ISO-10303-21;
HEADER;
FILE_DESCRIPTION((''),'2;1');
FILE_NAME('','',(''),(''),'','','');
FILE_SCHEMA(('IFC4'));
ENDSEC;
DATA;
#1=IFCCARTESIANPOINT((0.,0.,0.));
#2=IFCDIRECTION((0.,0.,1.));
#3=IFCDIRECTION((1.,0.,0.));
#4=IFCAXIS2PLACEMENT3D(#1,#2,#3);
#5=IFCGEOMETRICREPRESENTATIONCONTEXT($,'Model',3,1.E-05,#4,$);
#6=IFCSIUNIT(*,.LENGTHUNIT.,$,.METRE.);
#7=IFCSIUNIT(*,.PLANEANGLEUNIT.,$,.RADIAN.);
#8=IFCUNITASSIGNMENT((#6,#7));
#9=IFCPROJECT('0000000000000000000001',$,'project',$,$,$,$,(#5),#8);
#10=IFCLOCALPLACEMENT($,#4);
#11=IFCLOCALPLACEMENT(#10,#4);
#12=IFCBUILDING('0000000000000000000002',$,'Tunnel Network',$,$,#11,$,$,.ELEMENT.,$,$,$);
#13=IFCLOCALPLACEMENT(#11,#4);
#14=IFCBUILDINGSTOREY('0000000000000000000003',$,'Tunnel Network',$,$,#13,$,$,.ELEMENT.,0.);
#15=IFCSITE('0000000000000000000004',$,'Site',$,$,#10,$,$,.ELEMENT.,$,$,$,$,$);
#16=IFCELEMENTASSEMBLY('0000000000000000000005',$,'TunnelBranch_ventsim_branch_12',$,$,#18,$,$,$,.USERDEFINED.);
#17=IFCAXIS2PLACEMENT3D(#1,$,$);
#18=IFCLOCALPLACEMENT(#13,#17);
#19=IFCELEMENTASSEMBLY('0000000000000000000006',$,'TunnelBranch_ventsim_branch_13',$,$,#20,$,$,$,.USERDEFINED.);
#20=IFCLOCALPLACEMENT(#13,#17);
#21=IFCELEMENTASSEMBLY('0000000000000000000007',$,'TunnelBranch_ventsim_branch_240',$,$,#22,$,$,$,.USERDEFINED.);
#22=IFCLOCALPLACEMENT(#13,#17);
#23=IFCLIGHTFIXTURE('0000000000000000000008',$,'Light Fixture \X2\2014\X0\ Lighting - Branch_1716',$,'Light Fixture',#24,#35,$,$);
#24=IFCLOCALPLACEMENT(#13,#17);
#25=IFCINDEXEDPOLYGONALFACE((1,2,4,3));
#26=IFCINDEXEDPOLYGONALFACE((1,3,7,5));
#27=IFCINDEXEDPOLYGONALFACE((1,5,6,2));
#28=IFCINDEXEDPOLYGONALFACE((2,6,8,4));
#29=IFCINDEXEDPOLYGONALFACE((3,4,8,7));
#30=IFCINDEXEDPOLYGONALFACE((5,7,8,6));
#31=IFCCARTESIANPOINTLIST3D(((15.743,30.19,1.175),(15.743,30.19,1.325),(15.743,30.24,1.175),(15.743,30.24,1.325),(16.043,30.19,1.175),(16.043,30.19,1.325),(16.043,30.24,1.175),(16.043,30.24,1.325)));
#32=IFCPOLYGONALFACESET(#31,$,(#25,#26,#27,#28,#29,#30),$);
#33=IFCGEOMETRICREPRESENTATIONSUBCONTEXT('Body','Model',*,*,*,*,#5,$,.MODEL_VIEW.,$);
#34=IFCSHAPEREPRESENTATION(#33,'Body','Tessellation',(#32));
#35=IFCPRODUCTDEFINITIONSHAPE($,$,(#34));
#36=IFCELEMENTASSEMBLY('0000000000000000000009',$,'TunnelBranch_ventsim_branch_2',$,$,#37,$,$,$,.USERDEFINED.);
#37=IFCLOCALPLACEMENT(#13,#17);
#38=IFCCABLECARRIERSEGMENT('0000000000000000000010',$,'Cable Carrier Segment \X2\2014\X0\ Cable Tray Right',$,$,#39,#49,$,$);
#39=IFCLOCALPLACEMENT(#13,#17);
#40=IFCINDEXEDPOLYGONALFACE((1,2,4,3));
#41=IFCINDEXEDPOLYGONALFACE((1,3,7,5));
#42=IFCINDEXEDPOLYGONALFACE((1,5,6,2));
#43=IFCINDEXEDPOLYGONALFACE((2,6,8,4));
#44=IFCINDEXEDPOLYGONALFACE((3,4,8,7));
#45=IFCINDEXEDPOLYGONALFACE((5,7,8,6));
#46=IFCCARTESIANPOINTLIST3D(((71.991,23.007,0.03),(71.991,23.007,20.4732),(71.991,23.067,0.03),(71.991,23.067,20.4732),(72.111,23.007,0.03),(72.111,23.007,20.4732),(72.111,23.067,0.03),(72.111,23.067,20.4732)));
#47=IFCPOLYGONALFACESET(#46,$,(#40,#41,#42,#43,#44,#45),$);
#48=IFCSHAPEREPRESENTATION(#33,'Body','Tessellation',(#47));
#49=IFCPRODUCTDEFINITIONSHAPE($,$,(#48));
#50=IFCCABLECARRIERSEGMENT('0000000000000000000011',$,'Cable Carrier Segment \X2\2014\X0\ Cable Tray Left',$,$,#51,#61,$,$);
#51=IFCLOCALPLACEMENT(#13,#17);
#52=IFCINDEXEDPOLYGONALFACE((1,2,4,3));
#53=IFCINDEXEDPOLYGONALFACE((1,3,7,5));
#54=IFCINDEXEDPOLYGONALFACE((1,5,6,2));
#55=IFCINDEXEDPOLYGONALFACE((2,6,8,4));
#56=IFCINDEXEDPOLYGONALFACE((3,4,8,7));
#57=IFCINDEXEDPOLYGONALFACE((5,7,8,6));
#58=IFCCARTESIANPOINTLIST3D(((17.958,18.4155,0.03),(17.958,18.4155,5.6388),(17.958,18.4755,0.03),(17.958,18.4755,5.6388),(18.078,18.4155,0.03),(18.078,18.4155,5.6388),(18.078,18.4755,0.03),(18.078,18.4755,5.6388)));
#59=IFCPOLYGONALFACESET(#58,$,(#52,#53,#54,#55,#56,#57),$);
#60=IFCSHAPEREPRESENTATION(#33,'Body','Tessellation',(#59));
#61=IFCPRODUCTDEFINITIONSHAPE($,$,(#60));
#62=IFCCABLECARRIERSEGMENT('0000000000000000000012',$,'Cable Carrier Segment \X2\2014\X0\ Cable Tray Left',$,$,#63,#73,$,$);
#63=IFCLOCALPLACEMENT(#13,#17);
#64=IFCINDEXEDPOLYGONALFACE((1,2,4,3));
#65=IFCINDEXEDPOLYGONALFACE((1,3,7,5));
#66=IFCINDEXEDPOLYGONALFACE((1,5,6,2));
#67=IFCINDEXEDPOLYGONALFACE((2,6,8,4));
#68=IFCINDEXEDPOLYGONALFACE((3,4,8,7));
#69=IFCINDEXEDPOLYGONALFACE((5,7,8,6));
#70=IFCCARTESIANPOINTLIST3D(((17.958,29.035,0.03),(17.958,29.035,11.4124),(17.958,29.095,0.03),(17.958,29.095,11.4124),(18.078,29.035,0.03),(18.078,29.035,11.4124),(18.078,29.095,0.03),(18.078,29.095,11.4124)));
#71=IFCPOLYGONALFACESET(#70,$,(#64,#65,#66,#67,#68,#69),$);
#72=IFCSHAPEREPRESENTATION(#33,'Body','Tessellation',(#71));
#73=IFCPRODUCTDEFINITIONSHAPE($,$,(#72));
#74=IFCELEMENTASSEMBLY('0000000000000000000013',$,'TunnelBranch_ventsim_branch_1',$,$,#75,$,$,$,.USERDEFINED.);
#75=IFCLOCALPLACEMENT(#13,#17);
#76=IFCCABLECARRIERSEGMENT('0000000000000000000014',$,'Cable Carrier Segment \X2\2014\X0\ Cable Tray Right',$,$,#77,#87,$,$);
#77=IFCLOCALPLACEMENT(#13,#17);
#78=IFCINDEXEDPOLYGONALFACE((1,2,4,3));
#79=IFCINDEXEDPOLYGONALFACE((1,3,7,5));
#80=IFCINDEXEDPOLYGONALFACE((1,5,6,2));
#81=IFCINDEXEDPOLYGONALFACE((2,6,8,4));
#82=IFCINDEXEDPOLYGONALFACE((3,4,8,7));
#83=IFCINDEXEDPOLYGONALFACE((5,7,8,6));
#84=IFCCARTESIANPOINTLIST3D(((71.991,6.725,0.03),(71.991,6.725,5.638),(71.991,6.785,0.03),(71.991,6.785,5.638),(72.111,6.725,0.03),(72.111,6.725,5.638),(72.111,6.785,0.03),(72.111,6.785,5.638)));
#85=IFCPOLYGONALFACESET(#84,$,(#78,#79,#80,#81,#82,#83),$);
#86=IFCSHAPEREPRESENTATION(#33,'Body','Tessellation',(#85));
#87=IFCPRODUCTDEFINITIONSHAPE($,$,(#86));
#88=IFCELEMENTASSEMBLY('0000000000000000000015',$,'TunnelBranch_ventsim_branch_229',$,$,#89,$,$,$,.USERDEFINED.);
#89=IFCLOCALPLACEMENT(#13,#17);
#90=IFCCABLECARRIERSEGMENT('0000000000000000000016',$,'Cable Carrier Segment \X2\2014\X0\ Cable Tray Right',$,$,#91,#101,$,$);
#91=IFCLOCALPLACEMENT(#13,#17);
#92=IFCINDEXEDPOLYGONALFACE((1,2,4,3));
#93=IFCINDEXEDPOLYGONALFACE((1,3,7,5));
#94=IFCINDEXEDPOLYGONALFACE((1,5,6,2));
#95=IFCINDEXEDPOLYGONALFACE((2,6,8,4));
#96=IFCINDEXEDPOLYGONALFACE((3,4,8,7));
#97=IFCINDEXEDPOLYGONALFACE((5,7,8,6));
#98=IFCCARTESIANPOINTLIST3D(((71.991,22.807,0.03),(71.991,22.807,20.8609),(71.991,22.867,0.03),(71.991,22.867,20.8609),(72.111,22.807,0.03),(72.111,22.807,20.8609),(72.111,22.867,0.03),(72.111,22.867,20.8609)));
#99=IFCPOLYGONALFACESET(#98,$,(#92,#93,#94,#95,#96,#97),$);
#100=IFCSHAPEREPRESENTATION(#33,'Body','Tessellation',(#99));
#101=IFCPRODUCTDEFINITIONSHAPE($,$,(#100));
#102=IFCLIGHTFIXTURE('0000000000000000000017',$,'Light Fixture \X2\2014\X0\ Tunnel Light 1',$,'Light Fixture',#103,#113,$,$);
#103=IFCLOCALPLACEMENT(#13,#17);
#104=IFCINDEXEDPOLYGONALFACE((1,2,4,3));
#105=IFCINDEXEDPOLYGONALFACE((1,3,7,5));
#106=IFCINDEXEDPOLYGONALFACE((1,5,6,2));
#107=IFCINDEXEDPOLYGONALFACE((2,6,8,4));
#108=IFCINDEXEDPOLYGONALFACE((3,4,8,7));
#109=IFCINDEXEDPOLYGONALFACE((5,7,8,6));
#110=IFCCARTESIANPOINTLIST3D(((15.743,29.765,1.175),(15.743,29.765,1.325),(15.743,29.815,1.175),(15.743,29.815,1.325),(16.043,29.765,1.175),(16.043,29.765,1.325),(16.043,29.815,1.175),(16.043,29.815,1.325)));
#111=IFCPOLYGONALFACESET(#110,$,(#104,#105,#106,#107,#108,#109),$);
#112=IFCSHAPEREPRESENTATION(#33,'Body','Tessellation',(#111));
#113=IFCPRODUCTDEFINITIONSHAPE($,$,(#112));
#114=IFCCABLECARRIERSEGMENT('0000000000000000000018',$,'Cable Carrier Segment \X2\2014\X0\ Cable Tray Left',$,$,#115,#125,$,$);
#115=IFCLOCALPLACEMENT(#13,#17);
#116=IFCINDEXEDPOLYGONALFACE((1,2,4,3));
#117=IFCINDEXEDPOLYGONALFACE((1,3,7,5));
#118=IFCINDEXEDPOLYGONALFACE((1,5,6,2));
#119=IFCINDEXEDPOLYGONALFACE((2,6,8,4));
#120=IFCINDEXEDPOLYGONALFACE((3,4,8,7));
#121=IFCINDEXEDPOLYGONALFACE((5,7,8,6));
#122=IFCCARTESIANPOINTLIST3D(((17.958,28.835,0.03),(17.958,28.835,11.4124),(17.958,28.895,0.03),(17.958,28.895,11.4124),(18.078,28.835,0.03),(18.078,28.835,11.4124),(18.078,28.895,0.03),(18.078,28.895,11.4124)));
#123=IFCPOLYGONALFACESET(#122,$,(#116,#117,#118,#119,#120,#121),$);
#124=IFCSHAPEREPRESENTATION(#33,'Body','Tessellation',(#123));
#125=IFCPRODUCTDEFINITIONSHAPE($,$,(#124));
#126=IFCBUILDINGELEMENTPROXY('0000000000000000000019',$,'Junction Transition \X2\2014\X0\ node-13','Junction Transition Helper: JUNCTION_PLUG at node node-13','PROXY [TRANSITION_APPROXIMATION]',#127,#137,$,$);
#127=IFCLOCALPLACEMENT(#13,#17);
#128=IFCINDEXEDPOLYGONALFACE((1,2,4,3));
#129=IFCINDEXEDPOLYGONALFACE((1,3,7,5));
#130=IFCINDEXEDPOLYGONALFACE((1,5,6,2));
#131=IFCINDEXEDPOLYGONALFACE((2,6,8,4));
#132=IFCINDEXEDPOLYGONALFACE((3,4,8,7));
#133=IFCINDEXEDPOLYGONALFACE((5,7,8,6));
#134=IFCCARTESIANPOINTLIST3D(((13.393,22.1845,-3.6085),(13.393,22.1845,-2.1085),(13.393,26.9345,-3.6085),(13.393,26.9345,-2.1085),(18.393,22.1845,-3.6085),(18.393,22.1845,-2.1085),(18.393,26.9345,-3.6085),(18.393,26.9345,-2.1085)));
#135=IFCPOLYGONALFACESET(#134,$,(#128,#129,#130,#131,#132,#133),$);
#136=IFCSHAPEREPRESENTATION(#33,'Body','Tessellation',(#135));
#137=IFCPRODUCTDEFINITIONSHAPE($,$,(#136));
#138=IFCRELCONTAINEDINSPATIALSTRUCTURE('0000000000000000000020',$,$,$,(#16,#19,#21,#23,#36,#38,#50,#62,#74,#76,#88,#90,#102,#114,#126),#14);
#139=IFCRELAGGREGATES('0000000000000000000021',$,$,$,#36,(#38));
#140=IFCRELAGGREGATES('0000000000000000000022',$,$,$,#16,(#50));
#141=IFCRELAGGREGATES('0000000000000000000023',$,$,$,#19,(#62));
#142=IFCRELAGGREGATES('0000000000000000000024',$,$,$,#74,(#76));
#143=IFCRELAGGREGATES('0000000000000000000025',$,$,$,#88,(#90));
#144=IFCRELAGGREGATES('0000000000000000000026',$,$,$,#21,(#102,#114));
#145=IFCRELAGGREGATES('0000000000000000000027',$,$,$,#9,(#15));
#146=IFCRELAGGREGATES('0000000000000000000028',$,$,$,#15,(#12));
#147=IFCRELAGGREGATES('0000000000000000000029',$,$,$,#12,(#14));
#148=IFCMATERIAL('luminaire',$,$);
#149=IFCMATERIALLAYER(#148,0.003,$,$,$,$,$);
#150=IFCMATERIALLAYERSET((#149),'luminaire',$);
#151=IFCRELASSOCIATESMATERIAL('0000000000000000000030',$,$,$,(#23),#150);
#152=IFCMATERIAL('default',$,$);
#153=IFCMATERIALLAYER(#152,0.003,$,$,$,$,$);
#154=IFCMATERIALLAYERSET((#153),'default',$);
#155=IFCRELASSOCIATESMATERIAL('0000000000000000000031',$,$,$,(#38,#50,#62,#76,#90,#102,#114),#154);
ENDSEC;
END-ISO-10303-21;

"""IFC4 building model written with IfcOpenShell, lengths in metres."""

from ifc_helpers import new_model, si_unit, frame, origin_with_axes, origin_2d_with_axis, place, context, subcontext, project, spatial, rectangle, extrude, material, layer, layer_set, layer_usage, element, aggregate, save


model = new_model("IFC4")

# Units and contexts
model_context = context("Model", 3, precision=1e-05, world=origin_with_axes())
body_context = subcontext(model_context, "Body", "Model", "MODEL_VIEW")
ifc_project = project(units=[si_unit("LENGTHUNIT", "METRE"), si_unit("PLANEANGLEUNIT", "RADIAN")], contexts=[model_context])

# Site, building, storey
site_placement = place(None, origin_with_axes())
site = spatial("IfcSite", under=ifc_project, at=site_placement, Name="Site", CompositionType="ELEMENT")
building_placement = place(site_placement, origin_with_axes())
building = spatial("IfcBuilding", under=site, at=building_placement, Name="Tunnel Network", CompositionType="ELEMENT")
storey_placement = place(building_placement, origin_with_axes())
storey = spatial("IfcBuildingStorey", under=building, at=storey_placement, Name="Tunnel Network", CompositionType="ELEMENT", Elevation=0.0)

# Element assemblies
assembly_1_placement = place(storey_placement, frame((15.893, 19.5705, 0.7011), z_axis=(0.0, 0.0, 1.0), x_axis=(-1.0, 0.0, 0.0)))
assembly_1 = element("IfcElementAssembly", 1, at=assembly_1_placement, inside=storey, Name="TunnelBranch_ventsim_branch_12", PredefinedType="USERDEFINED")
ifc_material_1 = material(Name="default")
ifc_layer_1 = layer(ifc_material_1, 0.003)
ifc_layer_set_1 = layer_set([ifc_layer_1], Name="default")
assembly_2_placement = place(storey_placement, frame((15.893, 30.19, 1.25), z_axis=(0.0, 1.0, 0.0), x_axis=(-1.0, 0.0, 0.0)))
assembly_2 = element("IfcElementAssembly", 2, at=assembly_2_placement, inside=storey, Name="TunnelBranch_ventsim_branch_13", PredefinedType="USERDEFINED")
assembly_3_placement = place(storey_placement, frame((15.893, 29.765, 1.25), z_axis=(0.0, 1.0, 0.0), x_axis=(-1.0, 0.0, 0.0)))
assembly_3 = element("IfcElementAssembly", 3, at=assembly_3_placement, inside=storey, Name="TunnelBranch_ventsim_branch_240", PredefinedType="USERDEFINED")

# Shared definitions
ifc_material_2 = material(Name="luminaire")
ifc_layer_2 = layer(ifc_material_2, 0.003)
ifc_layer_set_2 = layer_set([ifc_layer_2], Name="luminaire")

# Light fixture
ifc_layer_usage_1 = layer_usage(ifc_layer_set_2, "AXIS2", "POSITIVE", 0.0)
light_fixture_1_placement = place(storey_placement, frame((15.893, 30.19, 1.25), z_axis=(0.0, 1.0, 0.0), x_axis=(-1.0, 0.0, 0.0)))
element("IfcLightFixture", 4, at=light_fixture_1_placement, inside=storey, material=ifc_layer_usage_1, Name="Light Fixture — Lighting - Branch_1716", ObjectType="Light Fixture", context=body_context, shape_type="SweptSolid", body=[
    extrude(rectangle(XDim=0.3, YDim=0.15, at=origin_2d_with_axis()), origin_with_axes(), (0.0, 0.0, 1.0), 0.05),
])

# Element assembly, cable carrier segment
assembly_4_placement = place(storey_placement, frame((74.176, 24.162, 1.25), z_axis=(0.0, 1.0, 0.0), x_axis=(-1.0, 0.0, 0.0)))
assembly_4 = element("IfcElementAssembly", 5, at=assembly_4_placement, inside=storey, Name="TunnelBranch_ventsim_branch_2", PredefinedType="USERDEFINED")
ifc_layer_usage_2 = layer_usage(ifc_layer_set_1, "AXIS2", "POSITIVE", 0.0)
cable_carrier_segment_1_placement = place(storey_placement, frame((72.051, 23.037, 0.03), z_axis=(0.0, 0.0, 1.0), x_axis=(-1.0, 0.0, 0.0)))
cable_carrier_segment_1 = element("IfcCableCarrierSegment", 6, at=cable_carrier_segment_1_placement, inside=storey, material=ifc_layer_usage_2, Name="Cable Carrier Segment — Cable Tray Right", context=body_context, shape_type="SweptSolid", body=[
    extrude(rectangle(XDim=0.12, YDim=0.06, at=origin_2d_with_axis()), origin_with_axes(), (0.0, 0.0, 1.0), 20.4432),
])
aggregate(assembly_4, [cable_carrier_segment_1])

# Cable carrier segment
ifc_layer_usage_3 = layer_usage(ifc_layer_set_1, "AXIS2", "POSITIVE", 0.0)
cable_carrier_segment_2_placement = place(storey_placement, frame((18.018, 18.4455, 0.03), z_axis=(0.0, 0.0, 1.0), x_axis=(-1.0, 0.0, 0.0)))
cable_carrier_segment_2 = element("IfcCableCarrierSegment", 7, at=cable_carrier_segment_2_placement, inside=storey, material=ifc_layer_usage_3, Name="Cable Carrier Segment — Cable Tray Left", context=body_context, shape_type="SweptSolid", body=[
    extrude(rectangle(XDim=0.12, YDim=0.06, at=origin_2d_with_axis()), origin_with_axes(), (0.0, 0.0, 1.0), 5.6088),
])
aggregate(assembly_1, [cable_carrier_segment_2])

# Cable carrier segment
ifc_layer_usage_4 = layer_usage(ifc_layer_set_1, "AXIS2", "POSITIVE", 0.0)
cable_carrier_segment_3_placement = place(storey_placement, frame((18.018, 29.065, 0.03), z_axis=(0.0, 0.0, 1.0), x_axis=(-1.0, 0.0, 0.0)))
cable_carrier_segment_3 = element("IfcCableCarrierSegment", 8, at=cable_carrier_segment_3_placement, inside=storey, material=ifc_layer_usage_4, Name="Cable Carrier Segment — Cable Tray Left", context=body_context, shape_type="SweptSolid", body=[
    extrude(rectangle(XDim=0.12, YDim=0.06, at=origin_2d_with_axis()), origin_with_axes(), (0.0, 0.0, 1.0), 11.3824),
])
aggregate(assembly_2, [cable_carrier_segment_3])

# Element assemblies, cable carrier segments
assembly_5_placement = place(storey_placement, frame((74.176, 7.88, 0.701), z_axis=(0.0, 0.0, 1.0), x_axis=(-1.0, 0.0, 0.0)))
assembly_5 = element("IfcElementAssembly", 9, at=assembly_5_placement, inside=storey, Name="TunnelBranch_ventsim_branch_1", PredefinedType="USERDEFINED")
ifc_layer_usage_5 = layer_usage(ifc_layer_set_1, "AXIS2", "POSITIVE", 0.0)
cable_carrier_segment_4_placement = place(storey_placement, frame((72.051, 6.755, 0.03), z_axis=(0.0, 0.0, 1.0), x_axis=(-1.0, 0.0, 0.0)))
cable_carrier_segment_4 = element("IfcCableCarrierSegment", 10, at=cable_carrier_segment_4_placement, inside=storey, material=ifc_layer_usage_5, Name="Cable Carrier Segment — Cable Tray Right", context=body_context, shape_type="SweptSolid", body=[
    extrude(rectangle(XDim=0.12, YDim=0.06, at=origin_2d_with_axis()), origin_with_axes(), (0.0, 0.0, 1.0), 5.608),
])
aggregate(assembly_5, [cable_carrier_segment_4])
assembly_6_placement = place(storey_placement, frame((74.176, 23.737, 1.25), z_axis=(0.0, 1.0, 0.0), x_axis=(-1.0, 0.0, 0.0)))
assembly_6 = element("IfcElementAssembly", 11, at=assembly_6_placement, inside=storey, Name="TunnelBranch_ventsim_branch_229", PredefinedType="USERDEFINED")
ifc_layer_usage_6 = layer_usage(ifc_layer_set_1, "AXIS2", "POSITIVE", 0.0)
cable_carrier_segment_5_placement = place(storey_placement, frame((72.051, 22.837, 0.03), z_axis=(0.0, 0.0, 1.0), x_axis=(-1.0, 0.0, 0.0)))
cable_carrier_segment_5 = element("IfcCableCarrierSegment", 12, at=cable_carrier_segment_5_placement, inside=storey, material=ifc_layer_usage_6, Name="Cable Carrier Segment — Cable Tray Right", context=body_context, shape_type="SweptSolid", body=[
    extrude(rectangle(XDim=0.12, YDim=0.06, at=origin_2d_with_axis()), origin_with_axes(), (0.0, 0.0, 1.0), 20.8309),
])
aggregate(assembly_6, [cable_carrier_segment_5])

# Light fixture
ifc_layer_usage_7 = layer_usage(ifc_layer_set_1, "AXIS2", "POSITIVE", 0.0)
light_fixture_2_placement = place(storey_placement, frame((15.893, 29.765, 1.25), z_axis=(0.0, 1.0, 0.0), x_axis=(-1.0, 0.0, 0.0)))
light_fixture_2 = element("IfcLightFixture", 13, at=light_fixture_2_placement, inside=storey, material=ifc_layer_usage_7, Name="Light Fixture — Tunnel Light 1", ObjectType="Light Fixture", context=body_context, shape_type="SweptSolid", body=[
    extrude(rectangle(XDim=0.3, YDim=0.15, at=origin_2d_with_axis()), origin_with_axes(), (0.0, 0.0, 1.0), 0.05),
])

# Cable carrier segment
ifc_layer_usage_8 = layer_usage(ifc_layer_set_1, "AXIS2", "POSITIVE", 0.0)
cable_carrier_segment_6_placement = place(storey_placement, frame((18.018, 28.865, 0.03), z_axis=(0.0, 0.0, 1.0), x_axis=(-1.0, 0.0, 0.0)))
cable_carrier_segment_6 = element("IfcCableCarrierSegment", 14, at=cable_carrier_segment_6_placement, inside=storey, material=ifc_layer_usage_8, Name="Cable Carrier Segment — Cable Tray Left", context=body_context, shape_type="SweptSolid", body=[
    extrude(rectangle(XDim=0.12, YDim=0.06, at=origin_2d_with_axis()), origin_with_axes(), (0.0, 0.0, 1.0), 11.3824),
])
aggregate(assembly_3, [light_fixture_2, cable_carrier_segment_6])

# Building element proxy
proxy_placement = place(storey_placement, frame((15.893, 24.5595, -3.6085), z_axis=(0.0, 0.0, 1.0), x_axis=(1.0, 0.0, 0.0)))
element("IfcBuildingElementProxy", 15, at=proxy_placement, inside=storey, Name="Junction Transition — node-13", Description="Junction Transition Helper: JUNCTION_PLUG at node node-13", ObjectType="PROXY [TRANSITION_APPROXIMATION]", context=body_context, shape_type="SweptSolid", body=[
    extrude(rectangle(XDim=5.0, YDim=4.75, at=origin_2d_with_axis()), origin_with_axes(), (0.0, 0.0, 1.0), 1.5),
])

save(model, "model.ifc")
